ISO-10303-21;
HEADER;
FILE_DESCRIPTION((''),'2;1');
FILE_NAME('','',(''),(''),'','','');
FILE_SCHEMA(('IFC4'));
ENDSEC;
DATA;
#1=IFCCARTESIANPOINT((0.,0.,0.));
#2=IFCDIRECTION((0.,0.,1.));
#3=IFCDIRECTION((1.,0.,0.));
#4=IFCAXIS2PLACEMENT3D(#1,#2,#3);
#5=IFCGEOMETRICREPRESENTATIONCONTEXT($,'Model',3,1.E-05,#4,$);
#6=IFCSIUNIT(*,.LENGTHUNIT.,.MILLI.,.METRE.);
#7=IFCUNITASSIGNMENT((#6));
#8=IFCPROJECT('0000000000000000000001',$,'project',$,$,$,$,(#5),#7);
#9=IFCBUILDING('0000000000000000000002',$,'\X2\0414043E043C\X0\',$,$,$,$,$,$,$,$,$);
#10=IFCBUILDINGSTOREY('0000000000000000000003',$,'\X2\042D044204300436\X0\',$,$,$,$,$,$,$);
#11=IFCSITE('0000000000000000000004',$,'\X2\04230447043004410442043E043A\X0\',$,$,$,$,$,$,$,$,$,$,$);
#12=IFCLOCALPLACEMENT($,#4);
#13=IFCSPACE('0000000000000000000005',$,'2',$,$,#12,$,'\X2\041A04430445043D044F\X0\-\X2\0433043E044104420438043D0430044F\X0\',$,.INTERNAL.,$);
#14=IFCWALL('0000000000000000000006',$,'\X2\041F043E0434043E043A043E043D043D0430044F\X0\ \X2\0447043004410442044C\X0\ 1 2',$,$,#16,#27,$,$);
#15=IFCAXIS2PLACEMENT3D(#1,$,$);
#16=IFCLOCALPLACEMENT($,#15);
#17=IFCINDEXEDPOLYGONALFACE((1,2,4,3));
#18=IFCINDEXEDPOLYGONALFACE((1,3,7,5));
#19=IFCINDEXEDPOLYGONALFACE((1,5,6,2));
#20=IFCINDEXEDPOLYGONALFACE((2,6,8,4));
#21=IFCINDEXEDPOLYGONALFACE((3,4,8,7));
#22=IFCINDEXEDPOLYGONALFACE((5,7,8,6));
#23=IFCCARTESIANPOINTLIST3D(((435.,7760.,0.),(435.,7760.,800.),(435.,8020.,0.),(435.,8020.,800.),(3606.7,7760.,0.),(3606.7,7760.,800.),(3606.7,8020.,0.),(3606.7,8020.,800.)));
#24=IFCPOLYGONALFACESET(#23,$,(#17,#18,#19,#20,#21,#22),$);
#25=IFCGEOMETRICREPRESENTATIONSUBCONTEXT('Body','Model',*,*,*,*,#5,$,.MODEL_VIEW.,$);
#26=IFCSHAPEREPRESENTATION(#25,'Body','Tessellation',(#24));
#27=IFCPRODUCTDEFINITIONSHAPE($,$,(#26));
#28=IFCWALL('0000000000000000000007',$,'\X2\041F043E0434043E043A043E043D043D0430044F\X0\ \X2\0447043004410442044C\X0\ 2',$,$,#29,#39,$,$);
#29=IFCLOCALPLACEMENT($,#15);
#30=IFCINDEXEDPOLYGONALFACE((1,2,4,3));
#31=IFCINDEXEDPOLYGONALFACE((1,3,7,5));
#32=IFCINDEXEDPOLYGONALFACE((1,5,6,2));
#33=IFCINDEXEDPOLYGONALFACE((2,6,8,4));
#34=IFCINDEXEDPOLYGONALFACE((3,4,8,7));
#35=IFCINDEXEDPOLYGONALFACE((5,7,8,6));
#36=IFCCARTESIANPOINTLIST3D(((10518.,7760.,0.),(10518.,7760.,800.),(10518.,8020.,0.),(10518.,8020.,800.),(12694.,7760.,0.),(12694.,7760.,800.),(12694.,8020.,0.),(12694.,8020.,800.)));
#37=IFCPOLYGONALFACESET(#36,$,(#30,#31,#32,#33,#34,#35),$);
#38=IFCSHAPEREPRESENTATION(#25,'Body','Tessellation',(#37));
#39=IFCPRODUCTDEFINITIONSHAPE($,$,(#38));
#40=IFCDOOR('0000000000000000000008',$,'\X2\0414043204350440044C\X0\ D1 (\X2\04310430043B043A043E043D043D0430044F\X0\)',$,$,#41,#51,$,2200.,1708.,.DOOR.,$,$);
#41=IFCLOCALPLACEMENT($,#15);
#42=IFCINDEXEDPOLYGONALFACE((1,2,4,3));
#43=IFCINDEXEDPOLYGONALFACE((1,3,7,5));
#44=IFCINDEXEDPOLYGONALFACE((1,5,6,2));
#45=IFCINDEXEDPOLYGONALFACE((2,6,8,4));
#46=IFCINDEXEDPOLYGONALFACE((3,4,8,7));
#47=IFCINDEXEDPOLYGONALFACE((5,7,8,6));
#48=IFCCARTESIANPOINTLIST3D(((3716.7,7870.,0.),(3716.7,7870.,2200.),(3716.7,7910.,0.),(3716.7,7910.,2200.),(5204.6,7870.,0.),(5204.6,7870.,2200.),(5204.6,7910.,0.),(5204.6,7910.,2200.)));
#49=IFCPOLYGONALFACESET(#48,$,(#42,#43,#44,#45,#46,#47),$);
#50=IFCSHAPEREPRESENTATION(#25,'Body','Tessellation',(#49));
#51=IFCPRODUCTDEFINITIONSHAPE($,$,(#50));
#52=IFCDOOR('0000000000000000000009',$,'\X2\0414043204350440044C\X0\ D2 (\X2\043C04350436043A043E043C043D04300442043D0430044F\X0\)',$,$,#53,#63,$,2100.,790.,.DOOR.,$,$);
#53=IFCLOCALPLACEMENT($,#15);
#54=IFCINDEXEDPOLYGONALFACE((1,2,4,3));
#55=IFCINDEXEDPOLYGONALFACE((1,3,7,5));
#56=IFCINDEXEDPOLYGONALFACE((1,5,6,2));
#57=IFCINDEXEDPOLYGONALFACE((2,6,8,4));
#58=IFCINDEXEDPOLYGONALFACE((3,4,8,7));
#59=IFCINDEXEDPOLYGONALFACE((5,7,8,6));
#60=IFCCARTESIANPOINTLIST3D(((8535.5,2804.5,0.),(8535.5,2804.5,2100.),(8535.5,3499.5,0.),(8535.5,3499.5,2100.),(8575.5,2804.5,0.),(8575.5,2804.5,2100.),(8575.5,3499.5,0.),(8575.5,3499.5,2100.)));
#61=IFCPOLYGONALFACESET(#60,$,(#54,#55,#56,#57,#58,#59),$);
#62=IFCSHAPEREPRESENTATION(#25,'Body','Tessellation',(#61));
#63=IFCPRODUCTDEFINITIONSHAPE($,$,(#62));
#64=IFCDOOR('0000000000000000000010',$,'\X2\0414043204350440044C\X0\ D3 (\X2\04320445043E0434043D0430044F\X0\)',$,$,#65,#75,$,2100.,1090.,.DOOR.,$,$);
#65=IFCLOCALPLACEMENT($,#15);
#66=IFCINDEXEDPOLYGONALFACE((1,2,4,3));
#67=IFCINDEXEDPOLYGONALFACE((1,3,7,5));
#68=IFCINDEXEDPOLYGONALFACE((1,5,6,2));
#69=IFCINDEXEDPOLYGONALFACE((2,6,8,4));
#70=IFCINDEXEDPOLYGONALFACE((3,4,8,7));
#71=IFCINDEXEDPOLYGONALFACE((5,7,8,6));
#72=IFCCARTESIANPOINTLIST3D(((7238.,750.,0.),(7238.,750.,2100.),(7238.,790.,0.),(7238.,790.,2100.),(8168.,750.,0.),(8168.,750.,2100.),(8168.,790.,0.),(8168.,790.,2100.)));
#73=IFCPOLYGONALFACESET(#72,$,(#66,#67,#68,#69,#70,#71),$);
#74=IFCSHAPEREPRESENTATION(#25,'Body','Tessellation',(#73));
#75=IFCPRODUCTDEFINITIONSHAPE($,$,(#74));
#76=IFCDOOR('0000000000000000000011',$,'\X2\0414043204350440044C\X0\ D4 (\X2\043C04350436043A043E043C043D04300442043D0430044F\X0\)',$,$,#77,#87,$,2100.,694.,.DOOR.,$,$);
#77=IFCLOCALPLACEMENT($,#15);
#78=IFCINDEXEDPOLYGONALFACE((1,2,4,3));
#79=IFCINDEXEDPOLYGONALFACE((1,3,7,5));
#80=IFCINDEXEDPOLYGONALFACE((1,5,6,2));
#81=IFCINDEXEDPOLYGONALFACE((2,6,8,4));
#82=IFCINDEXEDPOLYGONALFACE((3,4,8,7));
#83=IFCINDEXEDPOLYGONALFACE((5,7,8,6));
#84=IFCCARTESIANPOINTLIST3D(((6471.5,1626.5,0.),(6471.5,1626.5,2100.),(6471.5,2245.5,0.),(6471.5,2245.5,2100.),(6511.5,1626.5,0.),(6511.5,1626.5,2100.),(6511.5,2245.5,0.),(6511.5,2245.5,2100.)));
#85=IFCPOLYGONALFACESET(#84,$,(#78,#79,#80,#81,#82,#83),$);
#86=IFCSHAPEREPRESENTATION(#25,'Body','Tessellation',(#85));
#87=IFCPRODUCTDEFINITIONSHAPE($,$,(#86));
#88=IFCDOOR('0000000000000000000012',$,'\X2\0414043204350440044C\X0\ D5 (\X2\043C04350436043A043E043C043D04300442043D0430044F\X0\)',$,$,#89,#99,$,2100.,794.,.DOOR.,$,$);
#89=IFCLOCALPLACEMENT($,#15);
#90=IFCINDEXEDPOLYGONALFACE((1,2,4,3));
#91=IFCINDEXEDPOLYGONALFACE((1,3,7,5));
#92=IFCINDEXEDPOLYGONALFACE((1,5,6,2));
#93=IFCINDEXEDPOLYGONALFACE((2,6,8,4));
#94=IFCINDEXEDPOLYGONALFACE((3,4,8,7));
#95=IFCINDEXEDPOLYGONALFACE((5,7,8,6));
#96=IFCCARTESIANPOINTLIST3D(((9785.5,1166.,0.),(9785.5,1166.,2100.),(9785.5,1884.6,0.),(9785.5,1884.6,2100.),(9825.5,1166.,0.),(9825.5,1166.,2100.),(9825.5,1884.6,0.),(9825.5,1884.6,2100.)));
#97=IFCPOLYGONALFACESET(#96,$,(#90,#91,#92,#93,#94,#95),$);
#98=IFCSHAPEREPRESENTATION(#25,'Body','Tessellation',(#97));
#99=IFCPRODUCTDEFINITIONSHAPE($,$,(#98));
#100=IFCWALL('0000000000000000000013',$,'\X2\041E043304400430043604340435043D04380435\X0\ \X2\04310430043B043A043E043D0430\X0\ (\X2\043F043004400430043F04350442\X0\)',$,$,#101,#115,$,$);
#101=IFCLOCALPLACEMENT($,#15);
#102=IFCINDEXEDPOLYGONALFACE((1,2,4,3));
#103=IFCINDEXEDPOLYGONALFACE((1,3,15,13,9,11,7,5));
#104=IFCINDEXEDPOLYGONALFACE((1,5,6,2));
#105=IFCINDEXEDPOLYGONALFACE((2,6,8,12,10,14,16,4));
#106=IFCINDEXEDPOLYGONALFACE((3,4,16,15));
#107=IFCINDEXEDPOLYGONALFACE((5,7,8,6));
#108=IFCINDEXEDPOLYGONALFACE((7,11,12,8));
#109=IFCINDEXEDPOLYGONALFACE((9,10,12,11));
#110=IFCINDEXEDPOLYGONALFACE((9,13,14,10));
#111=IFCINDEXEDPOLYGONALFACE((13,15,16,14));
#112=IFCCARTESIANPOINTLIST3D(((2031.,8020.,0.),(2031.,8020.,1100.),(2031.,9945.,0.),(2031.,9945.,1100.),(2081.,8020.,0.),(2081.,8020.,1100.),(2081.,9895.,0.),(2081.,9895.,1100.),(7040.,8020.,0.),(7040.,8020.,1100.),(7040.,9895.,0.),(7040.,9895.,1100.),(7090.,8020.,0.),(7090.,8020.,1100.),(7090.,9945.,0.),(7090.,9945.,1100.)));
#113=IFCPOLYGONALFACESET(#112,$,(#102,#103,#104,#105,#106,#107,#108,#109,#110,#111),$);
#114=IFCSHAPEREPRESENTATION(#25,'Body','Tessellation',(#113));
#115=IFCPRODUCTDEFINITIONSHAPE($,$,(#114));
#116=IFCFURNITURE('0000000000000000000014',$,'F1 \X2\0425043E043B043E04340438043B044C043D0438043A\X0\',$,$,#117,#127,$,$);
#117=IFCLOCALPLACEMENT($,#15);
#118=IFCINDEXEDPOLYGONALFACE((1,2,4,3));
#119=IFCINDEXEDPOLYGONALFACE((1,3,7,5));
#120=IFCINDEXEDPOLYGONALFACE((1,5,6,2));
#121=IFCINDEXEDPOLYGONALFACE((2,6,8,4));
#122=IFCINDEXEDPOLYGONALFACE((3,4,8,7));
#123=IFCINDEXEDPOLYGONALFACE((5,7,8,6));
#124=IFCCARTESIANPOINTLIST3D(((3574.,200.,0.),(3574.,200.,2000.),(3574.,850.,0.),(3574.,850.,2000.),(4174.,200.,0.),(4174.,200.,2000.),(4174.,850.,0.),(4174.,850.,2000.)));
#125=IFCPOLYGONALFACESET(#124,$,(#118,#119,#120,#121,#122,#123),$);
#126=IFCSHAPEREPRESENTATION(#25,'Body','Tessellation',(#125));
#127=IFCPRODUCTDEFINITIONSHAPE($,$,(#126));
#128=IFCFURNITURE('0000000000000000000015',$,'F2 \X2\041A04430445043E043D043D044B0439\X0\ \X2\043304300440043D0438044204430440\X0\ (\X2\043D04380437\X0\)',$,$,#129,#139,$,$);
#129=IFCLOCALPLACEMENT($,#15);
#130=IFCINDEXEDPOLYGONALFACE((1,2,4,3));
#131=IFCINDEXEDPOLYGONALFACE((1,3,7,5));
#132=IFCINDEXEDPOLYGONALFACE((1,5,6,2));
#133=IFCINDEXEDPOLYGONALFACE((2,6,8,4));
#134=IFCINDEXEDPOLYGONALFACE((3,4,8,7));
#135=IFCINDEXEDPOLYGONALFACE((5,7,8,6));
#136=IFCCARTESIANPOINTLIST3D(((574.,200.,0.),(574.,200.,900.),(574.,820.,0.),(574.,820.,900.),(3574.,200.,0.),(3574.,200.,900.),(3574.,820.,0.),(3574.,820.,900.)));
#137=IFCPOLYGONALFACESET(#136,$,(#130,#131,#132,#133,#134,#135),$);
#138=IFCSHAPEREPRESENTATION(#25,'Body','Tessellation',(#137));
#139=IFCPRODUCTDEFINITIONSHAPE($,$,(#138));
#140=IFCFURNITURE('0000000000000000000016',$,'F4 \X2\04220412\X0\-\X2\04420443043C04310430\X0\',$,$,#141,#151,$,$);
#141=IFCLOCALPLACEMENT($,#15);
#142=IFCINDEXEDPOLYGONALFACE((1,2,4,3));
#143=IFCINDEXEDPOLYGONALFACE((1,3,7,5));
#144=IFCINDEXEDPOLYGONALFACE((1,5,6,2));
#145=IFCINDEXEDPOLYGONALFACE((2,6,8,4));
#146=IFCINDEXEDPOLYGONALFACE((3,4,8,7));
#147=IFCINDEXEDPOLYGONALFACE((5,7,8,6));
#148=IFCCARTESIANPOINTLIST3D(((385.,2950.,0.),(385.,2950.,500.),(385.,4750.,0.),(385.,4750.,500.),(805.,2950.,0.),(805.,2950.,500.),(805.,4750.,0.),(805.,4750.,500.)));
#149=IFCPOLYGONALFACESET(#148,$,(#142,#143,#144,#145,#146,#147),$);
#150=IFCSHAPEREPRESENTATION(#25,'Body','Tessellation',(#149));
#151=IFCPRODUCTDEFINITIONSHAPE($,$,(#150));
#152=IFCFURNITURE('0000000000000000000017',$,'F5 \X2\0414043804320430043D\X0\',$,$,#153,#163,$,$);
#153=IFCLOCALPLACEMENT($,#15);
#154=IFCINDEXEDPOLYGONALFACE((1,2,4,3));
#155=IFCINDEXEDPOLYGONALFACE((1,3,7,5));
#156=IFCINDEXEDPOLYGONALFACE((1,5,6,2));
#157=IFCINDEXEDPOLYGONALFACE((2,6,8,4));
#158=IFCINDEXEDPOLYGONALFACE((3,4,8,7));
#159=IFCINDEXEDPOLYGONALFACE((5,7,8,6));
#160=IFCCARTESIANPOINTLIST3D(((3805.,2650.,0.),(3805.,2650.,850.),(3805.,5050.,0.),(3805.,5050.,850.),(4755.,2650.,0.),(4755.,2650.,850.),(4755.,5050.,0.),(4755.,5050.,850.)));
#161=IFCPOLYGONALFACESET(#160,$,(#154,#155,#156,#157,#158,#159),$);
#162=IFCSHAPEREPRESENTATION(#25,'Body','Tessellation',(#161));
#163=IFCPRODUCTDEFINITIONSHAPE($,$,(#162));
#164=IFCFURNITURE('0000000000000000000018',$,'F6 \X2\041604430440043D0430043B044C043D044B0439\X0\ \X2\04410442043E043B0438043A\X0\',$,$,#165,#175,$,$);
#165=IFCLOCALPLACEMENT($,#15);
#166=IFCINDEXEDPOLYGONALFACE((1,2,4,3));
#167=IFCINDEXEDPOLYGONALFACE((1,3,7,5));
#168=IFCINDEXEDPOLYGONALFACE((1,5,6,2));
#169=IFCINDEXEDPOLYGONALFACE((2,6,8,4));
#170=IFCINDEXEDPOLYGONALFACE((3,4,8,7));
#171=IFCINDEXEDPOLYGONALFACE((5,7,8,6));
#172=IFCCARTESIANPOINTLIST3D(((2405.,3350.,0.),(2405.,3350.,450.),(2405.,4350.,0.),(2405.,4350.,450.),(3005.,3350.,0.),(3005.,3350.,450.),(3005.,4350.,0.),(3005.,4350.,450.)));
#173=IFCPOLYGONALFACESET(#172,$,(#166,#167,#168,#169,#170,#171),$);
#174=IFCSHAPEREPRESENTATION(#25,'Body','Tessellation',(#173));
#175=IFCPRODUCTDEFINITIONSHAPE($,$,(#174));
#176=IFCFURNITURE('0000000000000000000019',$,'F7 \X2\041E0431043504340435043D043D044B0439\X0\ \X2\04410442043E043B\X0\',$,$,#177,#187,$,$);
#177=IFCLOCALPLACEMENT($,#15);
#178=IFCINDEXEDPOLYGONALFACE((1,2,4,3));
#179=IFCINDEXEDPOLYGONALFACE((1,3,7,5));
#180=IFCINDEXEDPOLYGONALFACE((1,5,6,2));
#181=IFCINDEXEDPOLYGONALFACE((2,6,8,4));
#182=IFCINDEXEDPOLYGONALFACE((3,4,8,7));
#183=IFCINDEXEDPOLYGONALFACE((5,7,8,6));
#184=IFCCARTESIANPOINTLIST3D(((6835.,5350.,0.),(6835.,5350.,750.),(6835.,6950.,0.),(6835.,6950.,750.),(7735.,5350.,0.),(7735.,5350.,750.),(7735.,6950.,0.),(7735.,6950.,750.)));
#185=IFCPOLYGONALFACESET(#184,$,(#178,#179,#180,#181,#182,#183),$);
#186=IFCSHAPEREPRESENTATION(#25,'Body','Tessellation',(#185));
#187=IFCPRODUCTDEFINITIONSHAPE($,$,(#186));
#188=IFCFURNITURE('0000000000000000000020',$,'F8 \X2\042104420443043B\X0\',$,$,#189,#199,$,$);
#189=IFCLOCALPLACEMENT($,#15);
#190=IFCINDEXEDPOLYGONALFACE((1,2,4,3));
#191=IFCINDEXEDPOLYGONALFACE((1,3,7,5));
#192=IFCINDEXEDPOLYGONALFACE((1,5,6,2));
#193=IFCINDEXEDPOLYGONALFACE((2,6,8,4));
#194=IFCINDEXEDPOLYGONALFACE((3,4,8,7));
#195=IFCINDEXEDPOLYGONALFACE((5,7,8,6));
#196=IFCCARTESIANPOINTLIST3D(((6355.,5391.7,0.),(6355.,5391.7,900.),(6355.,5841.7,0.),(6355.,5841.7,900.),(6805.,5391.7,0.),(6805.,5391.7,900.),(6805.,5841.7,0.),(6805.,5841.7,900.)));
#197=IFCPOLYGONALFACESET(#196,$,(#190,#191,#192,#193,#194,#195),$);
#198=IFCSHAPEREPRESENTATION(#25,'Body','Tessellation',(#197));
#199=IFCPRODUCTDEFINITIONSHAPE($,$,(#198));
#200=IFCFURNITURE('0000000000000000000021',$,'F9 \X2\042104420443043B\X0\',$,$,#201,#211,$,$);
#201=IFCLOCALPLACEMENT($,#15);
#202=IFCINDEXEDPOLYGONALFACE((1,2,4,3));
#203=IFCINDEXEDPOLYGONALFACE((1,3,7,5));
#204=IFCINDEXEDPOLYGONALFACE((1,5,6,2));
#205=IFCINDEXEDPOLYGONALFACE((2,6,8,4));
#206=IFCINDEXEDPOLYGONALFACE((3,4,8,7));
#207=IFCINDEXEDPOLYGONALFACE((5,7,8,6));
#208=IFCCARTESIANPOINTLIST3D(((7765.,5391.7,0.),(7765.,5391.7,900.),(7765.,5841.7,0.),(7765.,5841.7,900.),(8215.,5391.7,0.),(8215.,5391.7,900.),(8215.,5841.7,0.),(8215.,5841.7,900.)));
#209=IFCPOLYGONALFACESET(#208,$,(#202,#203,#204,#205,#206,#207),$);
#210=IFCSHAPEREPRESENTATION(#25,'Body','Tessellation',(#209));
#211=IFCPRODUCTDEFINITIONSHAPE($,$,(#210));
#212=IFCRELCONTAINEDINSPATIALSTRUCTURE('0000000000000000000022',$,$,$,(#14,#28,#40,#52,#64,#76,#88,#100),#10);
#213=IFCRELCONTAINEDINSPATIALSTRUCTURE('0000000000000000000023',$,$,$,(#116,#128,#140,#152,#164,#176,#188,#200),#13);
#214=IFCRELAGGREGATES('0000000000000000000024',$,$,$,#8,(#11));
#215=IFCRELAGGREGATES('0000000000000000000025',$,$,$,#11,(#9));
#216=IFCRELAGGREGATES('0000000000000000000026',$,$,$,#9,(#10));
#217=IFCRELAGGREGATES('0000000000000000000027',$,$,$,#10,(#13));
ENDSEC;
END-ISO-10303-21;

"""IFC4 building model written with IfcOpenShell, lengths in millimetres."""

from ifc_helpers import new_model, si_unit, origin, origin_with_axes, place, context, subcontext, project, spatial, polyline, outline, extrude, element, save


model = new_model("IFC4")

# Units and contexts
model_context = context("Model", 3, precision=1e-05, world=origin_with_axes())
body_context = subcontext(model_context, "Body", "Model", "MODEL_VIEW")
ifc_project = project(units=[si_unit("LENGTHUNIT", "METRE", prefix="MILLI")], contexts=[model_context])

# Site, building, storey
site = spatial("IfcSite", under=ifc_project, Name="Участок")
building = spatial("IfcBuilding", under=site, Name="Дом")
storey = spatial("IfcBuildingStorey", under=building, Name="Этаж")

# Walls
wall_1_placement = place(None, origin_with_axes())
element("IfcWall", 1, at=wall_1_placement, inside=storey, Name="Подоконная часть 1 2", context=body_context, shape_type="SweptSolid", body=[
    extrude(outline(polyline([(435.0, 7760.0), (435.0, 8020.0), (3606.7, 8020.0), (3606.7, 7760.0), (5314.6, 7760.0), (435.0, 7760.0)])), origin(), (0.0, 0.0, 1.0), 800.0),
])
wall_2_placement = place(None, origin_with_axes())
element("IfcWall", 2, at=wall_2_placement, inside=storey, Name="Подоконная часть 2", context=body_context, shape_type="SweptSolid", body=[
    extrude(outline(polyline([(10518.0, 7760.0), (10518.0, 8020.0), (12694.0, 8020.0), (12694.0, 7760.0), (10518.0, 7760.0)])), origin(), (0.0, 0.0, 1.0), 800.0),
])

# Doors
door_1_placement = place(None, origin_with_axes())
element("IfcDoor", 3, at=door_1_placement, inside=storey, Name="Дверь D1 (балконная)", OverallHeight=2200.0, OverallWidth=1708.0, PredefinedType="DOOR", context=body_context, shape_type="SweptSolid", body=[
    extrude(outline(polyline([(5204.6, 7870.0), (3716.7, 7870.0), (3716.7, 7910.0), (5204.6, 7910.0), (5204.6, 7870.0)])), origin(), (0.0, 0.0, 1.0), 2200.0),
])
door_2_placement = place(None, origin_with_axes())
element("IfcDoor", 4, at=door_2_placement, inside=storey, Name="Дверь D2 (межкомнатная)", OverallHeight=2100.0, OverallWidth=790.0, PredefinedType="DOOR", context=body_context, shape_type="SweptSolid", body=[
    extrude(outline(polyline([(8535.5, 3499.5), (8575.5, 3499.5), (8575.5, 2804.5), (8535.5, 2804.5), (8535.5, 3499.5)])), origin(), (0.0, 0.0, 1.0), 2100.0),
])
door_3_placement = place(None, origin_with_axes())
element("IfcDoor", 5, at=door_3_placement, inside=storey, Name="Дверь D3 (входная)", OverallHeight=2100.0, OverallWidth=1090.0, PredefinedType="DOOR", context=body_context, shape_type="SweptSolid", body=[
    extrude(outline(polyline([(7238.0, 750.0), (7238.0, 790.0), (8168.0, 790.0), (8168.0, 750.0), (7238.0, 750.0)])), origin(), (0.0, 0.0, 1.0), 2100.0),
])
door_4_placement = place(None, origin_with_axes())
element("IfcDoor", 6, at=door_4_placement, inside=storey, Name="Дверь D4 (межкомнатная)", OverallHeight=2100.0, OverallWidth=694.0, PredefinedType="DOOR", context=body_context, shape_type="SweptSolid", body=[
    extrude(outline(polyline([(6511.5, 2245.5), (6511.5, 1626.5), (6471.5, 1626.5), (6471.5, 2245.5), (6511.5, 2245.5)])), origin(), (0.0, 0.0, 1.0), 2100.0),
])
door_5_placement = place(None, origin_with_axes())
element("IfcDoor", 7, at=door_5_placement, inside=storey, Name="Дверь D5 (межкомнатная)", OverallHeight=2100.0, OverallWidth=794.0, PredefinedType="DOOR", context=body_context, shape_type="SweptSolid", body=[
    extrude(outline(polyline([(9785.5, 1884.6), (9825.5, 1884.6), (9825.5, 1166.0), (9785.5, 1166.0), (9785.5, 1884.6)])), origin(), (0.0, 0.0, 1.0), 2100.0),
])

# Wall
wall_3_placement = place(None, origin_with_axes())
element("IfcWall", 8, at=wall_3_placement, inside=storey, Name="Ограждение балкона (парапет)", context=body_context, shape_type="SweptSolid", body=[
    extrude(outline(polyline([(2081.0, 8020.0), (2031.0, 8020.0), (2031.0, 9945.0), (7090.0, 9945.0), (7090.0, 8020.0), (7040.0, 8020.0), (7040.0, 9895.0), (2081.0, 9895.0), (2081.0, 8020.0)])), origin(), (0.0, 0.0, 1.0), 1100.0),
])

# Shared definitions
space_1_placement = place(None, origin_with_axes())
space_1 = spatial("IfcSpace", under=storey, at=space_1_placement, Name="2", LongName="Кухня-гостиная", PredefinedType="INTERNAL")

# Furniture
furniture_1_placement = place(space_1_placement, origin_with_axes())
element("IfcFurniture", 9, at=furniture_1_placement, inside=space_1, Name="F1 Холодильник", context=body_context, shape_type="SweptSolid", body=[
    extrude(outline(polyline([(4174.0, 200.0), (3574.0, 200.0), (3574.0, 850.0), (4174.0, 850.0), (4174.0, 200.0)])), origin(), (0.0, 0.0, 1.0), 2000.0),
])
furniture_2_placement = place(space_1_placement, origin_with_axes())
element("IfcFurniture", 10, at=furniture_2_placement, inside=space_1, Name="F2 Кухонный гарнитур (низ)", context=body_context, shape_type="SweptSolid", body=[
    extrude(outline(polyline([(3574.0, 200.0), (574.0, 200.0), (574.0, 820.0), (3574.0, 820.0), (3574.0, 200.0)])), origin(), (0.0, 0.0, 1.0), 900.0),
])
furniture_3_placement = place(space_1_placement, origin_with_axes())
element("IfcFurniture", 11, at=furniture_3_placement, inside=space_1, Name="F4 ТВ-тумба", context=body_context, shape_type="SweptSolid", body=[
    extrude(outline(polyline([(385.0, 2950.0), (385.0, 4750.0), (805.0, 4750.0), (805.0, 2950.0), (385.0, 2950.0)])), origin(), (0.0, 0.0, 1.0), 500.0),
])
furniture_4_placement = place(space_1_placement, origin_with_axes())
element("IfcFurniture", 12, at=furniture_4_placement, inside=space_1, Name="F5 Диван", context=body_context, shape_type="SweptSolid", body=[
    extrude(outline(polyline([(3805.0, 2650.0), (3805.0, 5050.0), (4755.0, 5050.0), (4755.0, 2650.0), (3805.0, 2650.0)])), origin(), (0.0, 0.0, 1.0), 850.0),
])
furniture_5_placement = place(space_1_placement, origin_with_axes())
element("IfcFurniture", 13, at=furniture_5_placement, inside=space_1, Name="F6 Журнальный столик", context=body_context, shape_type="SweptSolid", body=[
    extrude(outline(polyline([(3005.0, 3350.0), (3005.0, 4350.0), (2405.0, 4350.0), (2405.0, 3350.0), (3005.0, 3350.0)])), origin(), (0.0, 0.0, 1.0), 450.0),
])
furniture_6_placement = place(space_1_placement, origin_with_axes())
element("IfcFurniture", 14, at=furniture_6_placement, inside=space_1, Name="F7 Обеденный стол", context=body_context, shape_type="SweptSolid", body=[
    extrude(outline(polyline([(7735.0, 5350.0), (7735.0, 6950.0), (6835.0, 6950.0), (6835.0, 5350.0), (7735.0, 5350.0)])), origin(), (0.0, 0.0, 1.0), 750.0),
])
furniture_7_placement = place(space_1_placement, origin_with_axes())
element("IfcFurniture", 15, at=furniture_7_placement, inside=space_1, Name="F8 Стул", context=body_context, shape_type="SweptSolid", body=[
    extrude(outline(polyline([(6805.0, 5391.7), (6805.0, 5841.7), (6355.0, 5841.7), (6355.0, 5391.7), (6805.0, 5391.7)])), origin(), (0.0, 0.0, 1.0), 900.0),
])
furniture_8_placement = place(space_1_placement, origin_with_axes())
element("IfcFurniture", 16, at=furniture_8_placement, inside=space_1, Name="F9 Стул", context=body_context, shape_type="SweptSolid", body=[
    extrude(outline(polyline([(8215.0, 5391.7), (8215.0, 5841.7), (7765.0, 5841.7), (7765.0, 5391.7), (8215.0, 5391.7)])), origin(), (0.0, 0.0, 1.0), 900.0),
])

save(model, "model.ifc")
